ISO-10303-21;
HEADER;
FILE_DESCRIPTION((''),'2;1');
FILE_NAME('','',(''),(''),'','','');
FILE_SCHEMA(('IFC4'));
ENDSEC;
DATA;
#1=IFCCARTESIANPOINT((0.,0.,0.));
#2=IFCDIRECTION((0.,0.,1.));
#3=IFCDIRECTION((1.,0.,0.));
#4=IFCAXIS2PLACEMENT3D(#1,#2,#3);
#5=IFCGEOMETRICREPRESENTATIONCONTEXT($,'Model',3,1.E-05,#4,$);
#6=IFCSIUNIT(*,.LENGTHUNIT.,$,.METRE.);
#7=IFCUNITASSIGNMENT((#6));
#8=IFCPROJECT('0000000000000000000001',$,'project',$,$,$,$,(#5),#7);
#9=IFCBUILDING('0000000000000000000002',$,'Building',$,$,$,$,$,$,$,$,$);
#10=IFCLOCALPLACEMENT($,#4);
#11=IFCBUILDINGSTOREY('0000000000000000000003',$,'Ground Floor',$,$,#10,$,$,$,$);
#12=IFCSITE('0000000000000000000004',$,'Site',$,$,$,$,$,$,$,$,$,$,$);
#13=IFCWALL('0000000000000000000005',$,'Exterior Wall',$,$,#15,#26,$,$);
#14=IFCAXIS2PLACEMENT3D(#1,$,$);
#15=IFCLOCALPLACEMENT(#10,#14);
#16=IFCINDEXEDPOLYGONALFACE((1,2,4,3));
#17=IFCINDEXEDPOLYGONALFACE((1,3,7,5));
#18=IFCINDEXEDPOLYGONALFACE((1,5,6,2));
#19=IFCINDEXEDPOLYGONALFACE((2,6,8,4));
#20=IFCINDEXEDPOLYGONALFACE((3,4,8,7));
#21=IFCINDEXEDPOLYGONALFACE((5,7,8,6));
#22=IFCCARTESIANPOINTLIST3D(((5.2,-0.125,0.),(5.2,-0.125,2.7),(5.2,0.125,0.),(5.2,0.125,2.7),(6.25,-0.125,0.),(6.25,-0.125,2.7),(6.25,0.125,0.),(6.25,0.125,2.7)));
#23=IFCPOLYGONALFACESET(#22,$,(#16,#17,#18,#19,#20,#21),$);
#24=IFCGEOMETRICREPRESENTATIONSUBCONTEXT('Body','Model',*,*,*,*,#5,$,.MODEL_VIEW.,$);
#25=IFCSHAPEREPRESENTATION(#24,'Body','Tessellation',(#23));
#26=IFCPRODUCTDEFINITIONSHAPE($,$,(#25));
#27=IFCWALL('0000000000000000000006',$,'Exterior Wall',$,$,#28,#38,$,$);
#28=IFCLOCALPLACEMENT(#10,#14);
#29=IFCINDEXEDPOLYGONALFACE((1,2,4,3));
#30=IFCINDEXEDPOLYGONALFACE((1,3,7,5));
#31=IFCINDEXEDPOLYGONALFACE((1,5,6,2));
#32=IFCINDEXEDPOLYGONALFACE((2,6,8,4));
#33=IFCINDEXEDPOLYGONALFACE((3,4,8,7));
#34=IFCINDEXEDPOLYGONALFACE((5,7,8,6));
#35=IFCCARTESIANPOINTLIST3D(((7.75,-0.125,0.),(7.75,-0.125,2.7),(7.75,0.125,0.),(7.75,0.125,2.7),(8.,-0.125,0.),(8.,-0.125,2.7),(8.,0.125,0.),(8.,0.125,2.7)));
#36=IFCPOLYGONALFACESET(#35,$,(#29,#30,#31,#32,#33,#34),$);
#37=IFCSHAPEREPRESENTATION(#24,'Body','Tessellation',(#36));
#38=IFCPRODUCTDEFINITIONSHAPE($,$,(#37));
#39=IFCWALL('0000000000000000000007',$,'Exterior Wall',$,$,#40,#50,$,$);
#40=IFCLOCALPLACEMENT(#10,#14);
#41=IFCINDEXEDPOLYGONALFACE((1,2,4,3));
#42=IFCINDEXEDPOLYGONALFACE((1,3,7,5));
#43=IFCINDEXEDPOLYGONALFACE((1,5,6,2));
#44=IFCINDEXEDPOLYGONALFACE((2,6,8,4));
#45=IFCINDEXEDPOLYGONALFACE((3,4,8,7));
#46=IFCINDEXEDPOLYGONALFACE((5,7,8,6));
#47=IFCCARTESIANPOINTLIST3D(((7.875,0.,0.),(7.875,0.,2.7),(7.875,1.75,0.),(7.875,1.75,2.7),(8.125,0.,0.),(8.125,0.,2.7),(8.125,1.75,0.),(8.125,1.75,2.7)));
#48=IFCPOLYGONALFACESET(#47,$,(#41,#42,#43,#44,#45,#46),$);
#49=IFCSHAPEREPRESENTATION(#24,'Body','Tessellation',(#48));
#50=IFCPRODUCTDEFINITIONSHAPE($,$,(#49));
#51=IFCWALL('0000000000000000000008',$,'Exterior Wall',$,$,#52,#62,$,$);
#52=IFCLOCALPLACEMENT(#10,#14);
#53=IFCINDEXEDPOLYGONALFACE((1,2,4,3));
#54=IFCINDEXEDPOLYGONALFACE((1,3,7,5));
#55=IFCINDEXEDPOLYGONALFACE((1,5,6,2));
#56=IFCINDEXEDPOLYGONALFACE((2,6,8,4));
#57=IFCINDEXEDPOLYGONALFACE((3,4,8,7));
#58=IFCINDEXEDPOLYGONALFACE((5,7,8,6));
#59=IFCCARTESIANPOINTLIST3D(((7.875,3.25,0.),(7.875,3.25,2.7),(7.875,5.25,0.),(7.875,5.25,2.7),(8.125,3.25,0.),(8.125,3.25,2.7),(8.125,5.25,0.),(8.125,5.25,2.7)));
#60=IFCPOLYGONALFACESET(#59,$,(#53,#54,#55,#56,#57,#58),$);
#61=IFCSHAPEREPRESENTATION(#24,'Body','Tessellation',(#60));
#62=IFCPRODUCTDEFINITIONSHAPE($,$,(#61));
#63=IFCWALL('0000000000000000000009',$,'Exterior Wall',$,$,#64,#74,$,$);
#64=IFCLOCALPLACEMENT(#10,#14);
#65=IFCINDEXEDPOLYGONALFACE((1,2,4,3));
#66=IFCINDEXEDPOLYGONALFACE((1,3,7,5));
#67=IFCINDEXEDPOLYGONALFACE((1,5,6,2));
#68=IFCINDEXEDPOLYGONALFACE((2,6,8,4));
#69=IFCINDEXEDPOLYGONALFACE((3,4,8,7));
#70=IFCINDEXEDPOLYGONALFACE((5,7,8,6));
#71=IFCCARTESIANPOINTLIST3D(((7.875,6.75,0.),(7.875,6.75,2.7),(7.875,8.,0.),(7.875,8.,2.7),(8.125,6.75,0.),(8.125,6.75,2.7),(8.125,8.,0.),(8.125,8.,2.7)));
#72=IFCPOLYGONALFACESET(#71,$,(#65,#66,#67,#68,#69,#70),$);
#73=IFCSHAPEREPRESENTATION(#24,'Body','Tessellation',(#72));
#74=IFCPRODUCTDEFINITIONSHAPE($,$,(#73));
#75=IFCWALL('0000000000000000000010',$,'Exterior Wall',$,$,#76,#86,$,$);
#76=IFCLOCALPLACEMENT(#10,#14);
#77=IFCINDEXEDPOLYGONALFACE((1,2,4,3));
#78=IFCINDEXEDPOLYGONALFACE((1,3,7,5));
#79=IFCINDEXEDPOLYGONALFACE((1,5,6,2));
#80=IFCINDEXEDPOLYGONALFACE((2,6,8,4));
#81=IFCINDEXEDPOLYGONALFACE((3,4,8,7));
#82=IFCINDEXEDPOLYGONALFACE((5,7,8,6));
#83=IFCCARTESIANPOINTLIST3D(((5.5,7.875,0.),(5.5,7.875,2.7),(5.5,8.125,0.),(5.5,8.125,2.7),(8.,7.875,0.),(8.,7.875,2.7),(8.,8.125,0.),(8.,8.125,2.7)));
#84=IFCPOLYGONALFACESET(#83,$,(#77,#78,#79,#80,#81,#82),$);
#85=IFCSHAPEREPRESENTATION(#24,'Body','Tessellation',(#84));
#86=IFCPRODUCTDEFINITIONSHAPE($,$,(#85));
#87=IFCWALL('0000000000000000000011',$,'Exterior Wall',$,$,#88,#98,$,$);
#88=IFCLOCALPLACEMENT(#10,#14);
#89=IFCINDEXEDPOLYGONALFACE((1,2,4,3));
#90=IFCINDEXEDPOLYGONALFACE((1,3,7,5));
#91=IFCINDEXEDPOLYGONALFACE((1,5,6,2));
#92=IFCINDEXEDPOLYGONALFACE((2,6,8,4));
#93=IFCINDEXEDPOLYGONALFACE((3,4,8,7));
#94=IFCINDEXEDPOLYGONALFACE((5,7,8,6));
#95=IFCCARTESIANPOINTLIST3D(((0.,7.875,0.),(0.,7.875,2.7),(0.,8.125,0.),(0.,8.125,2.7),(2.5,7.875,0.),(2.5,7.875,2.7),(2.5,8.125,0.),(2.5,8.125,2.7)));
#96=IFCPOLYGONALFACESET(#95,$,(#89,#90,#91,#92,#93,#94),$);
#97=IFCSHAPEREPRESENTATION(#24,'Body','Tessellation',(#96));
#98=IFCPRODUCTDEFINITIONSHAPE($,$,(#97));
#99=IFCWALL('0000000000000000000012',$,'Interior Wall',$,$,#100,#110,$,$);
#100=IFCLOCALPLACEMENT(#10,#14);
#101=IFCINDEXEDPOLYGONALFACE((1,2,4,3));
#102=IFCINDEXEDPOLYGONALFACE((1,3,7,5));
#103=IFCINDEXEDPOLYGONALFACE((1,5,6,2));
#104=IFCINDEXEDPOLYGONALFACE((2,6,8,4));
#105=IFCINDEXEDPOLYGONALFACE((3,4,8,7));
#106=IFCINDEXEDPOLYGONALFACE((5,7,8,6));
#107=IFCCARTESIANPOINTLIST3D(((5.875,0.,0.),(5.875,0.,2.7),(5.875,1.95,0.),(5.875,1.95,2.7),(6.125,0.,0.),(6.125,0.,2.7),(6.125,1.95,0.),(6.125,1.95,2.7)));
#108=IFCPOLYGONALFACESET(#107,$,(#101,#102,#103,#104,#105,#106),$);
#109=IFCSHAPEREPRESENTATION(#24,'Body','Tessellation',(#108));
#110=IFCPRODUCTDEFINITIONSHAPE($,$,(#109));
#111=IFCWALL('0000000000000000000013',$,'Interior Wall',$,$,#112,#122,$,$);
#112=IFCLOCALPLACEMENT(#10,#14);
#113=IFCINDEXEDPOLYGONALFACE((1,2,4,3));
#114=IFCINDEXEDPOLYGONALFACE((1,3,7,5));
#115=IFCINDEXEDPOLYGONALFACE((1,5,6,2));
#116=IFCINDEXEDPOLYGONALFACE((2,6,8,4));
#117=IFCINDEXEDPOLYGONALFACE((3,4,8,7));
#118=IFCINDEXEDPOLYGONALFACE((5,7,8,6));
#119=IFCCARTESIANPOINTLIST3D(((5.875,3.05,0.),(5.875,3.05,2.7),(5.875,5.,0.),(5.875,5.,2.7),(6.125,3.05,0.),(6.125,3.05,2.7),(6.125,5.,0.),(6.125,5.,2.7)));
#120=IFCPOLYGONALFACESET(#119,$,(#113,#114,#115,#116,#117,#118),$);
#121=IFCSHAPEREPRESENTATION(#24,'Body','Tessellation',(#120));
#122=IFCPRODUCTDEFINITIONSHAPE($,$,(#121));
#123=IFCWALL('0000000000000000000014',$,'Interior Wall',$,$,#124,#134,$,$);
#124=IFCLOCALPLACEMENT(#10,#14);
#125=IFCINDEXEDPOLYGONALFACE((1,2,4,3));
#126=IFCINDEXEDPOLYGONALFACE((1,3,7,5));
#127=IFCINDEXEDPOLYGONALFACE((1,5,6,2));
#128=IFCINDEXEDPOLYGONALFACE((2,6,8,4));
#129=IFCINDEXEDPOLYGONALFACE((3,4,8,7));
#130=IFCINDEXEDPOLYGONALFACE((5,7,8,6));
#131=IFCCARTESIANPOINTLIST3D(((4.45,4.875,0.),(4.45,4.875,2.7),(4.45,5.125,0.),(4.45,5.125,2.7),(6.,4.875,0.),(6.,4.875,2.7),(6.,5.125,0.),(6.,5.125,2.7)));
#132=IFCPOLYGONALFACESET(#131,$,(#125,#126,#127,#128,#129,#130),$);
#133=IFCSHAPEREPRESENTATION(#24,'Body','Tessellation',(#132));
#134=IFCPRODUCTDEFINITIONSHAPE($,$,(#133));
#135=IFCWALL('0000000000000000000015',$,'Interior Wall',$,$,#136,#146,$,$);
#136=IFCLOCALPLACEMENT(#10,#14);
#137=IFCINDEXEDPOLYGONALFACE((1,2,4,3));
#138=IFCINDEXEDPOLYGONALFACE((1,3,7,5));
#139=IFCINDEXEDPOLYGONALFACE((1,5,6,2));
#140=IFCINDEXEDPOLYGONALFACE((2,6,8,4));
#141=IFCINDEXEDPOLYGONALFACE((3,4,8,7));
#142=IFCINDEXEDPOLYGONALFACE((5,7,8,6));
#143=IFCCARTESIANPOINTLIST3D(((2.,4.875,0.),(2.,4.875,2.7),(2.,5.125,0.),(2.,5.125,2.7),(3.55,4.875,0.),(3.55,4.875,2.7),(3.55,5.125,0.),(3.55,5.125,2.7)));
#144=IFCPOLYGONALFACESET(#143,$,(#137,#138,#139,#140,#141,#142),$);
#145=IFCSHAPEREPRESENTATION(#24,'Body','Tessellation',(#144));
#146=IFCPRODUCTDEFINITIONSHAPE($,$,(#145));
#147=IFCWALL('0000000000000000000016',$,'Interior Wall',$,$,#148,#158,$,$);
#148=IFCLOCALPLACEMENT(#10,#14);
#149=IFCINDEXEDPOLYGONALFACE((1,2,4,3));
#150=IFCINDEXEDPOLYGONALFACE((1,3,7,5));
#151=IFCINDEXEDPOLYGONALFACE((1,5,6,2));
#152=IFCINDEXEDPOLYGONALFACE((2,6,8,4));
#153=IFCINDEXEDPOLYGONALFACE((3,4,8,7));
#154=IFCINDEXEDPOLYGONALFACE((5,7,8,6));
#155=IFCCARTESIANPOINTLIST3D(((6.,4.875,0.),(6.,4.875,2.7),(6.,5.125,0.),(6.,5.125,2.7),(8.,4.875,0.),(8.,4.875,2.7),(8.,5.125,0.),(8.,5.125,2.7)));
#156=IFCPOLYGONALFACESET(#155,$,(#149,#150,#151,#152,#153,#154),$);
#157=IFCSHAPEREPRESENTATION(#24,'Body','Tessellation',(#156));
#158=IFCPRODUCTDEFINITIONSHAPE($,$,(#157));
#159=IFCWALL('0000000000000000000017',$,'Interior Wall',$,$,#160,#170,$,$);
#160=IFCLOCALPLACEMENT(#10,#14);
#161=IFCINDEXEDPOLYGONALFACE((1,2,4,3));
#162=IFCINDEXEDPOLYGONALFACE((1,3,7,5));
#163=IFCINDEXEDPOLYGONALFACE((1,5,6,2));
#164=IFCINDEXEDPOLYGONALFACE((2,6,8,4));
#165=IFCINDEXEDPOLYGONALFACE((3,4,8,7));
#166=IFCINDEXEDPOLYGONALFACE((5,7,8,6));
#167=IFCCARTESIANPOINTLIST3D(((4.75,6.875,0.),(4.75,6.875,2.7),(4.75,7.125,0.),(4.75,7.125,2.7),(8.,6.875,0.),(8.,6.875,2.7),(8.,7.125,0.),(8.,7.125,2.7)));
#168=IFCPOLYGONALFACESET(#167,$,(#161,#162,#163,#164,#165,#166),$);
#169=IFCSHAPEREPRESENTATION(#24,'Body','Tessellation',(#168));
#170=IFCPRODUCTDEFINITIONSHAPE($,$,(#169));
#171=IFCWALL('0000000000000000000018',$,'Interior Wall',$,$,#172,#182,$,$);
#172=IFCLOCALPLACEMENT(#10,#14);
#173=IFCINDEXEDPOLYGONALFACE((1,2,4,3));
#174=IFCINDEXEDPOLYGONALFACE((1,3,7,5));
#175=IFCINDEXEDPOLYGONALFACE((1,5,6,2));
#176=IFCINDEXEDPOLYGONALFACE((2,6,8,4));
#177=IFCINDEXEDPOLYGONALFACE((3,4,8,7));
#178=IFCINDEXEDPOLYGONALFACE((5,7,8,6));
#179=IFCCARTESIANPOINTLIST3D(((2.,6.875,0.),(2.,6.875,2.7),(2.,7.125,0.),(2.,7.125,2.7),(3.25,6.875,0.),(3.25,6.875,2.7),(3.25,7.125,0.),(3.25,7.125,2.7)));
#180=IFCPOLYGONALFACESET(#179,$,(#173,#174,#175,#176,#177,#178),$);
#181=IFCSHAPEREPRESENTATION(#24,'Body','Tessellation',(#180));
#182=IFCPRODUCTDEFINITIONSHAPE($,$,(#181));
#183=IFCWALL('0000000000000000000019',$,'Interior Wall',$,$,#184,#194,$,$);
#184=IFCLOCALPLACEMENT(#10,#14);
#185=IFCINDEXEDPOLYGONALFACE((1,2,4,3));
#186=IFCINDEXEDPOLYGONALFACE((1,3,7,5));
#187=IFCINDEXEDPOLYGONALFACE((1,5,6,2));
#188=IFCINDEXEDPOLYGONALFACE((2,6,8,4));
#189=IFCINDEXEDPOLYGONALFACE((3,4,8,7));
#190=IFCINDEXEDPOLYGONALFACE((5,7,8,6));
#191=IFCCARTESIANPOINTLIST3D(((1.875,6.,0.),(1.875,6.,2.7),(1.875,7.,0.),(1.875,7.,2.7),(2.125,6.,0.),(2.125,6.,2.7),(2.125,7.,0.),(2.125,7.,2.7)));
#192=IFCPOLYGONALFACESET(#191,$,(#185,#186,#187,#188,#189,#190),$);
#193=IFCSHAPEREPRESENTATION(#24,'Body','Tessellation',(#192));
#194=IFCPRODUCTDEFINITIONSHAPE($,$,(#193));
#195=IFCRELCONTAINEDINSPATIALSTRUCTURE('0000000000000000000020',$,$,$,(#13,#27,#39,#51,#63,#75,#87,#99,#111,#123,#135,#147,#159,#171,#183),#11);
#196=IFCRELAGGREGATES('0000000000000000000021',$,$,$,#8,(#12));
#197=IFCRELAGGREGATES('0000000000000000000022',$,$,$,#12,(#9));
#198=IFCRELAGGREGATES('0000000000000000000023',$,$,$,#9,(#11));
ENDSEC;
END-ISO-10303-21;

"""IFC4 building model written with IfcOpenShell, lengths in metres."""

from ifc_helpers import new_model, si_unit, frame, origin_with_axes, place, context, subcontext, project, spatial, indexed_curve, outline, extrude, element, save


model = new_model("IFC4")

# Units and contexts
model_context = context("Model", 3, precision=1e-05, world=origin_with_axes())
body_context = subcontext(model_context, "Body", "Model", "MODEL_VIEW")
ifc_project = project(units=[si_unit("LENGTHUNIT", "METRE")], contexts=[model_context])

# Site, building, storey
site = spatial("IfcSite", under=ifc_project, Name="Site")
building = spatial("IfcBuilding", under=site, Name="Building")
storey_placement = place(None, origin_with_axes())
storey = spatial("IfcBuildingStorey", under=building, at=storey_placement, Name="Ground Floor")

# Walls
wall_1_placement = place(storey_placement, frame((5.2, 0.0, 0.0), z_axis=(0.0, 0.0, 1.0), x_axis=(1.0, 0.0, 0.0)))
element("IfcWall", 1, at=wall_1_placement, inside=storey, Name="Exterior Wall", context=body_context, shape_type="SweptSolid", body=[
    extrude(outline(indexed_curve([(0.0, 0.0), (0.0, 0.25), (1.05, 0.25), (1.05, 0.0), (0.0, 0.0)], self_intersect=False)), frame((0.0, -0.125, 0.0), z_axis=(0.0, 0.0, 1.0), x_axis=(1.0, 0.0, 0.0)), (0.0, 0.0, 1.0), 2.7),
])
wall_2_placement = place(storey_placement, frame((7.75, 0.0, 0.0), z_axis=(0.0, 0.0, 1.0), x_axis=(1.0, 0.0, 0.0)))
element("IfcWall", 2, at=wall_2_placement, inside=storey, Name="Exterior Wall", context=body_context, shape_type="SweptSolid", body=[
    extrude(outline(indexed_curve([(0.0, 0.0), (0.0, 0.25), (0.25, 0.25), (0.25, 0.0), (0.0, 0.0)], self_intersect=False)), frame((0.0, -0.125, 0.0), z_axis=(0.0, 0.0, 1.0), x_axis=(1.0, 0.0, 0.0)), (0.0, 0.0, 1.0), 2.7),
])
wall_3_placement = place(storey_placement, frame((8.0, 0.0, 0.0), z_axis=(0.0, 0.0, 1.0), x_axis=(0.0, 1.0, 0.0)))
element("IfcWall", 3, at=wall_3_placement, inside=storey, Name="Exterior Wall", context=body_context, shape_type="SweptSolid", body=[
    extrude(outline(indexed_curve([(0.0, 0.0), (0.0, 0.25), (1.75, 0.25), (1.75, 0.0), (0.0, 0.0)], self_intersect=False)), frame((0.0, -0.125, 0.0), z_axis=(0.0, 0.0, 1.0), x_axis=(1.0, 0.0, 0.0)), (0.0, 0.0, 1.0), 2.7),
])
wall_4_placement = place(storey_placement, frame((8.0, 3.25, 0.0), z_axis=(0.0, 0.0, 1.0), x_axis=(0.0, 1.0, 0.0)))
element("IfcWall", 4, at=wall_4_placement, inside=storey, Name="Exterior Wall", context=body_context, shape_type="SweptSolid", body=[
    extrude(outline(indexed_curve([(0.0, 0.0), (0.0, 0.25), (2.0, 0.25), (2.0, 0.0), (0.0, 0.0)], self_intersect=False)), frame((0.0, -0.125, 0.0), z_axis=(0.0, 0.0, 1.0), x_axis=(1.0, 0.0, 0.0)), (0.0, 0.0, 1.0), 2.7),
])
wall_5_placement = place(storey_placement, frame((8.0, 6.75, 0.0), z_axis=(0.0, 0.0, 1.0), x_axis=(0.0, 1.0, 0.0)))
element("IfcWall", 5, at=wall_5_placement, inside=storey, Name="Exterior Wall", context=body_context, shape_type="SweptSolid", body=[
    extrude(outline(indexed_curve([(0.0, 0.0), (0.0, 0.25), (1.25, 0.25), (1.25, 0.0), (0.0, 0.0)], self_intersect=False)), frame((0.0, -0.125, 0.0), z_axis=(0.0, 0.0, 1.0), x_axis=(1.0, 0.0, 0.0)), (0.0, 0.0, 1.0), 2.7),
])
for number, where, z_axis, x_axis, name in (
    (6, (8.0, 8.0, 0.0), (0.0, 0.0, 1.0), (-1.0, 0.0, 0.0), "Exterior Wall"),
    (7, (2.5, 8.0, 0.0), (0.0, 0.0, 1.0), (-1.0, 0.0, 0.0), "Exterior Wall"),
):
    element("IfcWall", number, at=place(storey_placement, frame(where, z_axis=z_axis, x_axis=x_axis)), inside=storey, Name=name, context=body_context, shape_type="SweptSolid", body=[
        extrude(outline(indexed_curve([(0.0, 0.0), (0.0, 0.25), (2.5, 0.25), (2.5, 0.0), (0.0, 0.0)], self_intersect=False)), frame((0.0, -0.125, 0.0), z_axis=(0.0, 0.0, 1.0), x_axis=(1.0, 0.0, 0.0)), (0.0, 0.0, 1.0), 2.7),
    ])
wall_6_placement = place(storey_placement, frame((6.0, 0.0, 0.0), z_axis=(0.0, 0.0, 1.0), x_axis=(0.0, 1.0, 0.0)))
element("IfcWall", 8, at=wall_6_placement, inside=storey, Name="Interior Wall", context=body_context, shape_type="SweptSolid", body=[
    extrude(outline(indexed_curve([(0.0, 0.0), (0.0, 0.25), (1.95, 0.25), (1.95, 0.0), (0.0, 0.0)], self_intersect=False)), frame((0.0, -0.125, 0.0), z_axis=(0.0, 0.0, 1.0), x_axis=(1.0, 0.0, 0.0)), (0.0, 0.0, 1.0), 2.7),
])
wall_7_placement = place(storey_placement, frame((6.0, 3.05, 0.0), z_axis=(0.0, 0.0, 1.0), x_axis=(0.0, 1.0, 0.0)))
element("IfcWall", 9, at=wall_7_placement, inside=storey, Name="Interior Wall", context=body_context, shape_type="SweptSolid", body=[
    extrude(outline(indexed_curve([(0.0, 0.0), (0.0, 0.25), (1.95, 0.25), (1.95, 0.0), (0.0, 0.0)], self_intersect=False)), frame((0.0, -0.125, 0.0), z_axis=(0.0, 0.0, 1.0), x_axis=(1.0, 0.0, 0.0)), (0.0, 0.0, 1.0), 2.7),
])
for number, where, z_axis, x_axis, name in (
    (10, (6.0, 5.0, 0.0), (0.0, 0.0, 1.0), (-1.0, 0.0, 0.0), "Interior Wall"),
    (11, (3.55, 5.0, 0.0), (0.0, 0.0, 1.0), (-1.0, 0.0, 0.0), "Interior Wall"),
):
    element("IfcWall", number, at=place(storey_placement, frame(where, z_axis=z_axis, x_axis=x_axis)), inside=storey, Name=name, context=body_context, shape_type="SweptSolid", body=[
        extrude(outline(indexed_curve([(0.0, 0.0), (0.0, 0.25), (1.55, 0.25), (1.55, 0.0), (0.0, 0.0)], self_intersect=False)), frame((0.0, -0.125, 0.0), z_axis=(0.0, 0.0, 1.0), x_axis=(1.0, 0.0, 0.0)), (0.0, 0.0, 1.0), 2.7),
    ])
wall_8_placement = place(storey_placement, frame((8.0, 5.0, 0.0), z_axis=(0.0, 0.0, 1.0), x_axis=(-1.0, 0.0, 0.0)))
element("IfcWall", 12, at=wall_8_placement, inside=storey, Name="Interior Wall", context=body_context, shape_type="SweptSolid", body=[
    extrude(outline(indexed_curve([(0.0, 0.0), (0.0, 0.25), (2.0, 0.25), (2.0, 0.0), (0.0, 0.0)], self_intersect=False)), frame((0.0, -0.125, 0.0), z_axis=(0.0, 0.0, 1.0), x_axis=(1.0, 0.0, 0.0)), (0.0, 0.0, 1.0), 2.7),
])
wall_9_placement = place(storey_placement, frame((8.0, 7.0, 0.0), z_axis=(0.0, 0.0, 1.0), x_axis=(-1.0, 0.0, 0.0)))
element("IfcWall", 13, at=wall_9_placement, inside=storey, Name="Interior Wall", context=body_context, shape_type="SweptSolid", body=[
    extrude(outline(indexed_curve([(0.0, 0.0), (0.0, 0.25), (3.25, 0.25), (3.25, 0.0), (0.0, 0.0)], self_intersect=False)), frame((0.0, -0.125, 0.0), z_axis=(0.0, 0.0, 1.0), x_axis=(1.0, 0.0, 0.0)), (0.0, 0.0, 1.0), 2.7),
])
wall_10_placement = place(storey_placement, frame((3.25, 7.0, 0.0), z_axis=(0.0, 0.0, 1.0), x_axis=(-1.0, 0.0, 0.0)))
element("IfcWall", 14, at=wall_10_placement, inside=storey, Name="Interior Wall", context=body_context, shape_type="SweptSolid", body=[
    extrude(outline(indexed_curve([(0.0, 0.0), (0.0, 0.25), (1.25, 0.25), (1.25, 0.0), (0.0, 0.0)], self_intersect=False)), frame((0.0, -0.125, 0.0), z_axis=(0.0, 0.0, 1.0), x_axis=(1.0, 0.0, 0.0)), (0.0, 0.0, 1.0), 2.7),
])
wall_11_placement = place(storey_placement, frame((2.0, 7.0, 0.0), z_axis=(0.0, 0.0, 1.0), x_axis=(0.0, -1.0, 0.0)))
element("IfcWall", 15, at=wall_11_placement, inside=storey, Name="Interior Wall", context=body_context, shape_type="SweptSolid", body=[
    extrude(outline(indexed_curve([(0.0, 0.0), (0.0, 0.25), (1.0, 0.25), (1.0, 0.0), (0.0, 0.0)], self_intersect=False)), frame((0.0, -0.125, 0.0), z_axis=(0.0, 0.0, 1.0), x_axis=(1.0, 0.0, 0.0)), (0.0, 0.0, 1.0), 2.7),
])

save(model, "model.ifc")
